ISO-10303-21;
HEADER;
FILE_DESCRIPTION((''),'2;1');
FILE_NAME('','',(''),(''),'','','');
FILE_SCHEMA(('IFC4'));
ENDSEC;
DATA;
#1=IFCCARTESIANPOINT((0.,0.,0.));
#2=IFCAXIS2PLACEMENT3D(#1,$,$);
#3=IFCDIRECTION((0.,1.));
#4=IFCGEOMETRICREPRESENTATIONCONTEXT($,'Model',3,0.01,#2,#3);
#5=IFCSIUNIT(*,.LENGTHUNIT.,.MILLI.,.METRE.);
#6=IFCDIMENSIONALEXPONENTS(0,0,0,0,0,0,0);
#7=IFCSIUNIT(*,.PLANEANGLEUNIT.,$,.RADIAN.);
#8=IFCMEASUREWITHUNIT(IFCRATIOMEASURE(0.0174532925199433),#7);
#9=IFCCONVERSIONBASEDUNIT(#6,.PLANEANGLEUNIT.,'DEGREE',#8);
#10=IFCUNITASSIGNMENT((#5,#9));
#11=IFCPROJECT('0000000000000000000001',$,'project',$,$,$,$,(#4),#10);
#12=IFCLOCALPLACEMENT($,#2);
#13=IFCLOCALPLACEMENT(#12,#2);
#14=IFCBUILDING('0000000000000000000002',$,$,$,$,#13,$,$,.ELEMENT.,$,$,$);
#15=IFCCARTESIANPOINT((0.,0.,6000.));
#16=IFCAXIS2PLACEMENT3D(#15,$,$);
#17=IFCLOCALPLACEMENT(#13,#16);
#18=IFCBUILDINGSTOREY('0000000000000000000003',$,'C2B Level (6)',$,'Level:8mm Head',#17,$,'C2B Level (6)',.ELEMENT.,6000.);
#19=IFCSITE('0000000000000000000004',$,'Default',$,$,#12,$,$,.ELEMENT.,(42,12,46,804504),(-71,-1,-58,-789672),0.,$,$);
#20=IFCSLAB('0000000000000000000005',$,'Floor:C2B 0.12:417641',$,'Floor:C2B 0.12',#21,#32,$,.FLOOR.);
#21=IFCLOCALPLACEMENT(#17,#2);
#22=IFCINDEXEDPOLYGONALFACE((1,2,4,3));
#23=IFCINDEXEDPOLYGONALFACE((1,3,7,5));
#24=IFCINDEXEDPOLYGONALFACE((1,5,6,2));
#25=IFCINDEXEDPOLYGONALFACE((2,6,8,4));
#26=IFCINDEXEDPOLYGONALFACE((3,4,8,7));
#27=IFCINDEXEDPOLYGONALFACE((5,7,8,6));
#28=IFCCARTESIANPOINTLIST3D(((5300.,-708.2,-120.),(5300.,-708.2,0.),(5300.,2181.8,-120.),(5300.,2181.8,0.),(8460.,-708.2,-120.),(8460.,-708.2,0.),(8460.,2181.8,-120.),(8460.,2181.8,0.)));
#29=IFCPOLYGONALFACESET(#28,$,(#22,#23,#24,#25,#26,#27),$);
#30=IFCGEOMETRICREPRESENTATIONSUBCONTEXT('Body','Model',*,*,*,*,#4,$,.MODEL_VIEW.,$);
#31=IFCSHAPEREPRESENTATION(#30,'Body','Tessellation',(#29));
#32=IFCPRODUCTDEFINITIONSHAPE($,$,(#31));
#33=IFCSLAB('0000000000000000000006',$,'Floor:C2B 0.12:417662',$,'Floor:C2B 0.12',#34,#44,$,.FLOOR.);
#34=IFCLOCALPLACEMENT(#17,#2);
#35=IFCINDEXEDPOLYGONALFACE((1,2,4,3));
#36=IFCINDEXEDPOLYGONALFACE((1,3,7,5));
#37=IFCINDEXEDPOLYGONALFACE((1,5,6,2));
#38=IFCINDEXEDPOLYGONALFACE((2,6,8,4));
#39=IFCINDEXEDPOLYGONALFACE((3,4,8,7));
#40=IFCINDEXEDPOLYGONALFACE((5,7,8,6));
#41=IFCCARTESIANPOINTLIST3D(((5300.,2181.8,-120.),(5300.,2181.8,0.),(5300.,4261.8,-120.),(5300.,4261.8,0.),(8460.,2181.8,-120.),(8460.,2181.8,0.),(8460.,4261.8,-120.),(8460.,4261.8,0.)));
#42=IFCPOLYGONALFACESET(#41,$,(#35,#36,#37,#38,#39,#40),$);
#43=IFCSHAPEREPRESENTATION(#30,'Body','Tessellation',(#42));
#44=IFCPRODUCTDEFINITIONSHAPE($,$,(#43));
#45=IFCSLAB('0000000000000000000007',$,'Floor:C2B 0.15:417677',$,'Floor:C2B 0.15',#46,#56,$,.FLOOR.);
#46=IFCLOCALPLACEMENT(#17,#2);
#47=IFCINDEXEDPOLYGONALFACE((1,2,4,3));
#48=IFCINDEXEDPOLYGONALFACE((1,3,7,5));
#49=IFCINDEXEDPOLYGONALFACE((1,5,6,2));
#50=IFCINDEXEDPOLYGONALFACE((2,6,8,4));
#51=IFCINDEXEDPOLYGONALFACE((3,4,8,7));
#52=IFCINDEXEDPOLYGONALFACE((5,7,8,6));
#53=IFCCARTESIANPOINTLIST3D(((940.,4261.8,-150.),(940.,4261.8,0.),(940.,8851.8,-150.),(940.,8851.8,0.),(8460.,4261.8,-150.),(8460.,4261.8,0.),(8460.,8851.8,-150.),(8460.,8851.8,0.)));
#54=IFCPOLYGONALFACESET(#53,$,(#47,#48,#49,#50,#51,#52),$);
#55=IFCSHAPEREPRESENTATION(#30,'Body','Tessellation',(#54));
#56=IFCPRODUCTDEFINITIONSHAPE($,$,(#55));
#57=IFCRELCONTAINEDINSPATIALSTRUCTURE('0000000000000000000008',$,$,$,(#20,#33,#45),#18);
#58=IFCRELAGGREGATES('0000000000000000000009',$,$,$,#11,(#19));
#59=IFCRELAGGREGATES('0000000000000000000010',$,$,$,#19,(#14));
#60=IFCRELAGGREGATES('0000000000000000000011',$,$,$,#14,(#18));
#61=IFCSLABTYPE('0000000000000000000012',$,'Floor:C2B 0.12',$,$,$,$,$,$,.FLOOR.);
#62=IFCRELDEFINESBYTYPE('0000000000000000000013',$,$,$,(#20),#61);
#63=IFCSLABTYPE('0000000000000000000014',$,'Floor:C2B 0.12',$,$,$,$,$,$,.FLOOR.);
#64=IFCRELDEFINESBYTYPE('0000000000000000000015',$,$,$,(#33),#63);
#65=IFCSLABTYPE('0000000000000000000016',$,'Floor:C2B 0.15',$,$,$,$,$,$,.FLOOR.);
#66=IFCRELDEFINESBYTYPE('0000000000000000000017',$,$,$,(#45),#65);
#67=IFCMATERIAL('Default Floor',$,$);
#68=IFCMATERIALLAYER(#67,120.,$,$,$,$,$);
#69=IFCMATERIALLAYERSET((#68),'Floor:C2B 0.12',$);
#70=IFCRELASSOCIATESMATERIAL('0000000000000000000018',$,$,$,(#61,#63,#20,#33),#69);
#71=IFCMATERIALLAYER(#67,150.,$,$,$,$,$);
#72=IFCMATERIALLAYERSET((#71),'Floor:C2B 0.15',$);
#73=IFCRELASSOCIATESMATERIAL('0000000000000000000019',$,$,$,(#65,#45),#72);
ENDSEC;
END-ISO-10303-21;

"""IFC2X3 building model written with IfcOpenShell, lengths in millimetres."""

from ifc_helpers import new_model, entity, si_unit, converted_unit, direction, frame, frame_2d, origin, origin_2d_with_axis, place, context, subcontext, project, spatial, rectangle, extrude, material, layer, layer_set, layer_usage, type_object, element, save


model = new_model("IFC2X3")

# Units and contexts
model_context = context("Model", 3, precision=0.01, world=origin(), true_north=direction((0.0, 1.0)))
body_context = subcontext(model_context, "Body", "Model", "MODEL_VIEW")
ifc_project = project(units=[si_unit("LENGTHUNIT", "METRE", prefix="MILLI"), converted_unit("PLANEANGLEUNIT", "DEGREE", entity("IfcRatioMeasure", 0.0174532925199433), si_unit("PLANEANGLEUNIT", "RADIAN"), dimensions=[0, 0, 0, 0, 0, 0, 0])], contexts=[model_context])

# Site, building, storey
site_placement = place(None, origin())
site = spatial("IfcSite", under=ifc_project, at=site_placement, Name="Default", CompositionType="ELEMENT", RefLatitude=(42, 12, 46, 804504), RefLongitude=(-71, -1, -58, -789672), RefElevation=0.0)
building_placement = place(site_placement, origin())
building = spatial("IfcBuilding", under=site, at=building_placement, CompositionType="ELEMENT")
storey_placement = place(building_placement, frame((0.0, 0.0, 6000.0)))
storey = spatial("IfcBuildingStorey", under=building, at=storey_placement, Name="C2B Level (6)", ObjectType="Level:8mm Head", LongName="C2B Level (6)", CompositionType="ELEMENT", Elevation=6000.0)

# Slabs
ifc_material_1 = material(Name="Default Floor")
ifc_layer_1 = layer(ifc_material_1, 120.0)
ifc_layer_set_1 = layer_set([ifc_layer_1], Name="Floor:C2B 0.12")
ifc_layer_usage_1 = layer_usage(ifc_layer_set_1, "AXIS3", "POSITIVE", 0.0)
slab_type_1 = type_object("IfcSlabType", Name="Floor:C2B 0.12", PredefinedType="FLOOR", material=ifc_layer_set_1)
slab_1_placement = place(storey_placement, origin())
element("IfcSlab", 1, at=slab_1_placement, inside=storey, type_object=slab_type_1, material=ifc_layer_usage_1, Name="Floor:C2B 0.12:417641", ObjectType="Floor:C2B 0.12", PredefinedType="FLOOR", context=body_context, shape_type="SweptSolid", body=[
    extrude(rectangle(XDim=2890.0, YDim=3160.0, at=origin_2d_with_axis()), frame((6880.0, 736.8, 0.0), z_axis=(0.0, 0.0, -1.0), x_axis=(0.0, 1.0, 0.0)), (0.0, 0.0, 1.0), 120.0),
])
ifc_layer_usage_2 = layer_usage(ifc_layer_set_1, "AXIS3", "POSITIVE", 0.0)
slab_type_2 = type_object("IfcSlabType", Name="Floor:C2B 0.12", PredefinedType="FLOOR", material=ifc_layer_set_1)
slab_2_placement = place(storey_placement, origin())
element("IfcSlab", 2, at=slab_2_placement, inside=storey, type_object=slab_type_2, material=ifc_layer_usage_2, Name="Floor:C2B 0.12:417662", ObjectType="Floor:C2B 0.12", PredefinedType="FLOOR", context=body_context, shape_type="SweptSolid", body=[
    extrude(rectangle(XDim=2080.0, YDim=3160.0, at=frame_2d((0.0, 0.0), x_axis=(1.0, 0.0))), frame((6880.0, 3221.8, 0.0), z_axis=(0.0, 0.0, -1.0), x_axis=(0.0, 1.0, 0.0)), (0.0, 0.0, 1.0), 120.0),
])
ifc_layer_2 = layer(ifc_material_1, 150.0)
ifc_layer_set_2 = layer_set([ifc_layer_2], Name="Floor:C2B 0.15")
ifc_layer_usage_3 = layer_usage(ifc_layer_set_2, "AXIS3", "POSITIVE", 0.0)
slab_type_3 = type_object("IfcSlabType", Name="Floor:C2B 0.15", PredefinedType="FLOOR", material=ifc_layer_set_2)
slab_3_placement = place(storey_placement, origin())
element("IfcSlab", 3, at=slab_3_placement, inside=storey, type_object=slab_type_3, material=ifc_layer_usage_3, Name="Floor:C2B 0.15:417677", ObjectType="Floor:C2B 0.15", PredefinedType="FLOOR", context=body_context, shape_type="SweptSolid", body=[
    extrude(rectangle(XDim=4590.0, YDim=7520.0, at=frame_2d((0.0, 0.0), x_axis=(1.0, 0.0))), frame((4700.0, 6556.8, 0.0), z_axis=(0.0, 0.0, -1.0), x_axis=(0.0, 1.0, 0.0)), (0.0, 0.0, 1.0), 150.0),
])

save(model, "model.ifc")
